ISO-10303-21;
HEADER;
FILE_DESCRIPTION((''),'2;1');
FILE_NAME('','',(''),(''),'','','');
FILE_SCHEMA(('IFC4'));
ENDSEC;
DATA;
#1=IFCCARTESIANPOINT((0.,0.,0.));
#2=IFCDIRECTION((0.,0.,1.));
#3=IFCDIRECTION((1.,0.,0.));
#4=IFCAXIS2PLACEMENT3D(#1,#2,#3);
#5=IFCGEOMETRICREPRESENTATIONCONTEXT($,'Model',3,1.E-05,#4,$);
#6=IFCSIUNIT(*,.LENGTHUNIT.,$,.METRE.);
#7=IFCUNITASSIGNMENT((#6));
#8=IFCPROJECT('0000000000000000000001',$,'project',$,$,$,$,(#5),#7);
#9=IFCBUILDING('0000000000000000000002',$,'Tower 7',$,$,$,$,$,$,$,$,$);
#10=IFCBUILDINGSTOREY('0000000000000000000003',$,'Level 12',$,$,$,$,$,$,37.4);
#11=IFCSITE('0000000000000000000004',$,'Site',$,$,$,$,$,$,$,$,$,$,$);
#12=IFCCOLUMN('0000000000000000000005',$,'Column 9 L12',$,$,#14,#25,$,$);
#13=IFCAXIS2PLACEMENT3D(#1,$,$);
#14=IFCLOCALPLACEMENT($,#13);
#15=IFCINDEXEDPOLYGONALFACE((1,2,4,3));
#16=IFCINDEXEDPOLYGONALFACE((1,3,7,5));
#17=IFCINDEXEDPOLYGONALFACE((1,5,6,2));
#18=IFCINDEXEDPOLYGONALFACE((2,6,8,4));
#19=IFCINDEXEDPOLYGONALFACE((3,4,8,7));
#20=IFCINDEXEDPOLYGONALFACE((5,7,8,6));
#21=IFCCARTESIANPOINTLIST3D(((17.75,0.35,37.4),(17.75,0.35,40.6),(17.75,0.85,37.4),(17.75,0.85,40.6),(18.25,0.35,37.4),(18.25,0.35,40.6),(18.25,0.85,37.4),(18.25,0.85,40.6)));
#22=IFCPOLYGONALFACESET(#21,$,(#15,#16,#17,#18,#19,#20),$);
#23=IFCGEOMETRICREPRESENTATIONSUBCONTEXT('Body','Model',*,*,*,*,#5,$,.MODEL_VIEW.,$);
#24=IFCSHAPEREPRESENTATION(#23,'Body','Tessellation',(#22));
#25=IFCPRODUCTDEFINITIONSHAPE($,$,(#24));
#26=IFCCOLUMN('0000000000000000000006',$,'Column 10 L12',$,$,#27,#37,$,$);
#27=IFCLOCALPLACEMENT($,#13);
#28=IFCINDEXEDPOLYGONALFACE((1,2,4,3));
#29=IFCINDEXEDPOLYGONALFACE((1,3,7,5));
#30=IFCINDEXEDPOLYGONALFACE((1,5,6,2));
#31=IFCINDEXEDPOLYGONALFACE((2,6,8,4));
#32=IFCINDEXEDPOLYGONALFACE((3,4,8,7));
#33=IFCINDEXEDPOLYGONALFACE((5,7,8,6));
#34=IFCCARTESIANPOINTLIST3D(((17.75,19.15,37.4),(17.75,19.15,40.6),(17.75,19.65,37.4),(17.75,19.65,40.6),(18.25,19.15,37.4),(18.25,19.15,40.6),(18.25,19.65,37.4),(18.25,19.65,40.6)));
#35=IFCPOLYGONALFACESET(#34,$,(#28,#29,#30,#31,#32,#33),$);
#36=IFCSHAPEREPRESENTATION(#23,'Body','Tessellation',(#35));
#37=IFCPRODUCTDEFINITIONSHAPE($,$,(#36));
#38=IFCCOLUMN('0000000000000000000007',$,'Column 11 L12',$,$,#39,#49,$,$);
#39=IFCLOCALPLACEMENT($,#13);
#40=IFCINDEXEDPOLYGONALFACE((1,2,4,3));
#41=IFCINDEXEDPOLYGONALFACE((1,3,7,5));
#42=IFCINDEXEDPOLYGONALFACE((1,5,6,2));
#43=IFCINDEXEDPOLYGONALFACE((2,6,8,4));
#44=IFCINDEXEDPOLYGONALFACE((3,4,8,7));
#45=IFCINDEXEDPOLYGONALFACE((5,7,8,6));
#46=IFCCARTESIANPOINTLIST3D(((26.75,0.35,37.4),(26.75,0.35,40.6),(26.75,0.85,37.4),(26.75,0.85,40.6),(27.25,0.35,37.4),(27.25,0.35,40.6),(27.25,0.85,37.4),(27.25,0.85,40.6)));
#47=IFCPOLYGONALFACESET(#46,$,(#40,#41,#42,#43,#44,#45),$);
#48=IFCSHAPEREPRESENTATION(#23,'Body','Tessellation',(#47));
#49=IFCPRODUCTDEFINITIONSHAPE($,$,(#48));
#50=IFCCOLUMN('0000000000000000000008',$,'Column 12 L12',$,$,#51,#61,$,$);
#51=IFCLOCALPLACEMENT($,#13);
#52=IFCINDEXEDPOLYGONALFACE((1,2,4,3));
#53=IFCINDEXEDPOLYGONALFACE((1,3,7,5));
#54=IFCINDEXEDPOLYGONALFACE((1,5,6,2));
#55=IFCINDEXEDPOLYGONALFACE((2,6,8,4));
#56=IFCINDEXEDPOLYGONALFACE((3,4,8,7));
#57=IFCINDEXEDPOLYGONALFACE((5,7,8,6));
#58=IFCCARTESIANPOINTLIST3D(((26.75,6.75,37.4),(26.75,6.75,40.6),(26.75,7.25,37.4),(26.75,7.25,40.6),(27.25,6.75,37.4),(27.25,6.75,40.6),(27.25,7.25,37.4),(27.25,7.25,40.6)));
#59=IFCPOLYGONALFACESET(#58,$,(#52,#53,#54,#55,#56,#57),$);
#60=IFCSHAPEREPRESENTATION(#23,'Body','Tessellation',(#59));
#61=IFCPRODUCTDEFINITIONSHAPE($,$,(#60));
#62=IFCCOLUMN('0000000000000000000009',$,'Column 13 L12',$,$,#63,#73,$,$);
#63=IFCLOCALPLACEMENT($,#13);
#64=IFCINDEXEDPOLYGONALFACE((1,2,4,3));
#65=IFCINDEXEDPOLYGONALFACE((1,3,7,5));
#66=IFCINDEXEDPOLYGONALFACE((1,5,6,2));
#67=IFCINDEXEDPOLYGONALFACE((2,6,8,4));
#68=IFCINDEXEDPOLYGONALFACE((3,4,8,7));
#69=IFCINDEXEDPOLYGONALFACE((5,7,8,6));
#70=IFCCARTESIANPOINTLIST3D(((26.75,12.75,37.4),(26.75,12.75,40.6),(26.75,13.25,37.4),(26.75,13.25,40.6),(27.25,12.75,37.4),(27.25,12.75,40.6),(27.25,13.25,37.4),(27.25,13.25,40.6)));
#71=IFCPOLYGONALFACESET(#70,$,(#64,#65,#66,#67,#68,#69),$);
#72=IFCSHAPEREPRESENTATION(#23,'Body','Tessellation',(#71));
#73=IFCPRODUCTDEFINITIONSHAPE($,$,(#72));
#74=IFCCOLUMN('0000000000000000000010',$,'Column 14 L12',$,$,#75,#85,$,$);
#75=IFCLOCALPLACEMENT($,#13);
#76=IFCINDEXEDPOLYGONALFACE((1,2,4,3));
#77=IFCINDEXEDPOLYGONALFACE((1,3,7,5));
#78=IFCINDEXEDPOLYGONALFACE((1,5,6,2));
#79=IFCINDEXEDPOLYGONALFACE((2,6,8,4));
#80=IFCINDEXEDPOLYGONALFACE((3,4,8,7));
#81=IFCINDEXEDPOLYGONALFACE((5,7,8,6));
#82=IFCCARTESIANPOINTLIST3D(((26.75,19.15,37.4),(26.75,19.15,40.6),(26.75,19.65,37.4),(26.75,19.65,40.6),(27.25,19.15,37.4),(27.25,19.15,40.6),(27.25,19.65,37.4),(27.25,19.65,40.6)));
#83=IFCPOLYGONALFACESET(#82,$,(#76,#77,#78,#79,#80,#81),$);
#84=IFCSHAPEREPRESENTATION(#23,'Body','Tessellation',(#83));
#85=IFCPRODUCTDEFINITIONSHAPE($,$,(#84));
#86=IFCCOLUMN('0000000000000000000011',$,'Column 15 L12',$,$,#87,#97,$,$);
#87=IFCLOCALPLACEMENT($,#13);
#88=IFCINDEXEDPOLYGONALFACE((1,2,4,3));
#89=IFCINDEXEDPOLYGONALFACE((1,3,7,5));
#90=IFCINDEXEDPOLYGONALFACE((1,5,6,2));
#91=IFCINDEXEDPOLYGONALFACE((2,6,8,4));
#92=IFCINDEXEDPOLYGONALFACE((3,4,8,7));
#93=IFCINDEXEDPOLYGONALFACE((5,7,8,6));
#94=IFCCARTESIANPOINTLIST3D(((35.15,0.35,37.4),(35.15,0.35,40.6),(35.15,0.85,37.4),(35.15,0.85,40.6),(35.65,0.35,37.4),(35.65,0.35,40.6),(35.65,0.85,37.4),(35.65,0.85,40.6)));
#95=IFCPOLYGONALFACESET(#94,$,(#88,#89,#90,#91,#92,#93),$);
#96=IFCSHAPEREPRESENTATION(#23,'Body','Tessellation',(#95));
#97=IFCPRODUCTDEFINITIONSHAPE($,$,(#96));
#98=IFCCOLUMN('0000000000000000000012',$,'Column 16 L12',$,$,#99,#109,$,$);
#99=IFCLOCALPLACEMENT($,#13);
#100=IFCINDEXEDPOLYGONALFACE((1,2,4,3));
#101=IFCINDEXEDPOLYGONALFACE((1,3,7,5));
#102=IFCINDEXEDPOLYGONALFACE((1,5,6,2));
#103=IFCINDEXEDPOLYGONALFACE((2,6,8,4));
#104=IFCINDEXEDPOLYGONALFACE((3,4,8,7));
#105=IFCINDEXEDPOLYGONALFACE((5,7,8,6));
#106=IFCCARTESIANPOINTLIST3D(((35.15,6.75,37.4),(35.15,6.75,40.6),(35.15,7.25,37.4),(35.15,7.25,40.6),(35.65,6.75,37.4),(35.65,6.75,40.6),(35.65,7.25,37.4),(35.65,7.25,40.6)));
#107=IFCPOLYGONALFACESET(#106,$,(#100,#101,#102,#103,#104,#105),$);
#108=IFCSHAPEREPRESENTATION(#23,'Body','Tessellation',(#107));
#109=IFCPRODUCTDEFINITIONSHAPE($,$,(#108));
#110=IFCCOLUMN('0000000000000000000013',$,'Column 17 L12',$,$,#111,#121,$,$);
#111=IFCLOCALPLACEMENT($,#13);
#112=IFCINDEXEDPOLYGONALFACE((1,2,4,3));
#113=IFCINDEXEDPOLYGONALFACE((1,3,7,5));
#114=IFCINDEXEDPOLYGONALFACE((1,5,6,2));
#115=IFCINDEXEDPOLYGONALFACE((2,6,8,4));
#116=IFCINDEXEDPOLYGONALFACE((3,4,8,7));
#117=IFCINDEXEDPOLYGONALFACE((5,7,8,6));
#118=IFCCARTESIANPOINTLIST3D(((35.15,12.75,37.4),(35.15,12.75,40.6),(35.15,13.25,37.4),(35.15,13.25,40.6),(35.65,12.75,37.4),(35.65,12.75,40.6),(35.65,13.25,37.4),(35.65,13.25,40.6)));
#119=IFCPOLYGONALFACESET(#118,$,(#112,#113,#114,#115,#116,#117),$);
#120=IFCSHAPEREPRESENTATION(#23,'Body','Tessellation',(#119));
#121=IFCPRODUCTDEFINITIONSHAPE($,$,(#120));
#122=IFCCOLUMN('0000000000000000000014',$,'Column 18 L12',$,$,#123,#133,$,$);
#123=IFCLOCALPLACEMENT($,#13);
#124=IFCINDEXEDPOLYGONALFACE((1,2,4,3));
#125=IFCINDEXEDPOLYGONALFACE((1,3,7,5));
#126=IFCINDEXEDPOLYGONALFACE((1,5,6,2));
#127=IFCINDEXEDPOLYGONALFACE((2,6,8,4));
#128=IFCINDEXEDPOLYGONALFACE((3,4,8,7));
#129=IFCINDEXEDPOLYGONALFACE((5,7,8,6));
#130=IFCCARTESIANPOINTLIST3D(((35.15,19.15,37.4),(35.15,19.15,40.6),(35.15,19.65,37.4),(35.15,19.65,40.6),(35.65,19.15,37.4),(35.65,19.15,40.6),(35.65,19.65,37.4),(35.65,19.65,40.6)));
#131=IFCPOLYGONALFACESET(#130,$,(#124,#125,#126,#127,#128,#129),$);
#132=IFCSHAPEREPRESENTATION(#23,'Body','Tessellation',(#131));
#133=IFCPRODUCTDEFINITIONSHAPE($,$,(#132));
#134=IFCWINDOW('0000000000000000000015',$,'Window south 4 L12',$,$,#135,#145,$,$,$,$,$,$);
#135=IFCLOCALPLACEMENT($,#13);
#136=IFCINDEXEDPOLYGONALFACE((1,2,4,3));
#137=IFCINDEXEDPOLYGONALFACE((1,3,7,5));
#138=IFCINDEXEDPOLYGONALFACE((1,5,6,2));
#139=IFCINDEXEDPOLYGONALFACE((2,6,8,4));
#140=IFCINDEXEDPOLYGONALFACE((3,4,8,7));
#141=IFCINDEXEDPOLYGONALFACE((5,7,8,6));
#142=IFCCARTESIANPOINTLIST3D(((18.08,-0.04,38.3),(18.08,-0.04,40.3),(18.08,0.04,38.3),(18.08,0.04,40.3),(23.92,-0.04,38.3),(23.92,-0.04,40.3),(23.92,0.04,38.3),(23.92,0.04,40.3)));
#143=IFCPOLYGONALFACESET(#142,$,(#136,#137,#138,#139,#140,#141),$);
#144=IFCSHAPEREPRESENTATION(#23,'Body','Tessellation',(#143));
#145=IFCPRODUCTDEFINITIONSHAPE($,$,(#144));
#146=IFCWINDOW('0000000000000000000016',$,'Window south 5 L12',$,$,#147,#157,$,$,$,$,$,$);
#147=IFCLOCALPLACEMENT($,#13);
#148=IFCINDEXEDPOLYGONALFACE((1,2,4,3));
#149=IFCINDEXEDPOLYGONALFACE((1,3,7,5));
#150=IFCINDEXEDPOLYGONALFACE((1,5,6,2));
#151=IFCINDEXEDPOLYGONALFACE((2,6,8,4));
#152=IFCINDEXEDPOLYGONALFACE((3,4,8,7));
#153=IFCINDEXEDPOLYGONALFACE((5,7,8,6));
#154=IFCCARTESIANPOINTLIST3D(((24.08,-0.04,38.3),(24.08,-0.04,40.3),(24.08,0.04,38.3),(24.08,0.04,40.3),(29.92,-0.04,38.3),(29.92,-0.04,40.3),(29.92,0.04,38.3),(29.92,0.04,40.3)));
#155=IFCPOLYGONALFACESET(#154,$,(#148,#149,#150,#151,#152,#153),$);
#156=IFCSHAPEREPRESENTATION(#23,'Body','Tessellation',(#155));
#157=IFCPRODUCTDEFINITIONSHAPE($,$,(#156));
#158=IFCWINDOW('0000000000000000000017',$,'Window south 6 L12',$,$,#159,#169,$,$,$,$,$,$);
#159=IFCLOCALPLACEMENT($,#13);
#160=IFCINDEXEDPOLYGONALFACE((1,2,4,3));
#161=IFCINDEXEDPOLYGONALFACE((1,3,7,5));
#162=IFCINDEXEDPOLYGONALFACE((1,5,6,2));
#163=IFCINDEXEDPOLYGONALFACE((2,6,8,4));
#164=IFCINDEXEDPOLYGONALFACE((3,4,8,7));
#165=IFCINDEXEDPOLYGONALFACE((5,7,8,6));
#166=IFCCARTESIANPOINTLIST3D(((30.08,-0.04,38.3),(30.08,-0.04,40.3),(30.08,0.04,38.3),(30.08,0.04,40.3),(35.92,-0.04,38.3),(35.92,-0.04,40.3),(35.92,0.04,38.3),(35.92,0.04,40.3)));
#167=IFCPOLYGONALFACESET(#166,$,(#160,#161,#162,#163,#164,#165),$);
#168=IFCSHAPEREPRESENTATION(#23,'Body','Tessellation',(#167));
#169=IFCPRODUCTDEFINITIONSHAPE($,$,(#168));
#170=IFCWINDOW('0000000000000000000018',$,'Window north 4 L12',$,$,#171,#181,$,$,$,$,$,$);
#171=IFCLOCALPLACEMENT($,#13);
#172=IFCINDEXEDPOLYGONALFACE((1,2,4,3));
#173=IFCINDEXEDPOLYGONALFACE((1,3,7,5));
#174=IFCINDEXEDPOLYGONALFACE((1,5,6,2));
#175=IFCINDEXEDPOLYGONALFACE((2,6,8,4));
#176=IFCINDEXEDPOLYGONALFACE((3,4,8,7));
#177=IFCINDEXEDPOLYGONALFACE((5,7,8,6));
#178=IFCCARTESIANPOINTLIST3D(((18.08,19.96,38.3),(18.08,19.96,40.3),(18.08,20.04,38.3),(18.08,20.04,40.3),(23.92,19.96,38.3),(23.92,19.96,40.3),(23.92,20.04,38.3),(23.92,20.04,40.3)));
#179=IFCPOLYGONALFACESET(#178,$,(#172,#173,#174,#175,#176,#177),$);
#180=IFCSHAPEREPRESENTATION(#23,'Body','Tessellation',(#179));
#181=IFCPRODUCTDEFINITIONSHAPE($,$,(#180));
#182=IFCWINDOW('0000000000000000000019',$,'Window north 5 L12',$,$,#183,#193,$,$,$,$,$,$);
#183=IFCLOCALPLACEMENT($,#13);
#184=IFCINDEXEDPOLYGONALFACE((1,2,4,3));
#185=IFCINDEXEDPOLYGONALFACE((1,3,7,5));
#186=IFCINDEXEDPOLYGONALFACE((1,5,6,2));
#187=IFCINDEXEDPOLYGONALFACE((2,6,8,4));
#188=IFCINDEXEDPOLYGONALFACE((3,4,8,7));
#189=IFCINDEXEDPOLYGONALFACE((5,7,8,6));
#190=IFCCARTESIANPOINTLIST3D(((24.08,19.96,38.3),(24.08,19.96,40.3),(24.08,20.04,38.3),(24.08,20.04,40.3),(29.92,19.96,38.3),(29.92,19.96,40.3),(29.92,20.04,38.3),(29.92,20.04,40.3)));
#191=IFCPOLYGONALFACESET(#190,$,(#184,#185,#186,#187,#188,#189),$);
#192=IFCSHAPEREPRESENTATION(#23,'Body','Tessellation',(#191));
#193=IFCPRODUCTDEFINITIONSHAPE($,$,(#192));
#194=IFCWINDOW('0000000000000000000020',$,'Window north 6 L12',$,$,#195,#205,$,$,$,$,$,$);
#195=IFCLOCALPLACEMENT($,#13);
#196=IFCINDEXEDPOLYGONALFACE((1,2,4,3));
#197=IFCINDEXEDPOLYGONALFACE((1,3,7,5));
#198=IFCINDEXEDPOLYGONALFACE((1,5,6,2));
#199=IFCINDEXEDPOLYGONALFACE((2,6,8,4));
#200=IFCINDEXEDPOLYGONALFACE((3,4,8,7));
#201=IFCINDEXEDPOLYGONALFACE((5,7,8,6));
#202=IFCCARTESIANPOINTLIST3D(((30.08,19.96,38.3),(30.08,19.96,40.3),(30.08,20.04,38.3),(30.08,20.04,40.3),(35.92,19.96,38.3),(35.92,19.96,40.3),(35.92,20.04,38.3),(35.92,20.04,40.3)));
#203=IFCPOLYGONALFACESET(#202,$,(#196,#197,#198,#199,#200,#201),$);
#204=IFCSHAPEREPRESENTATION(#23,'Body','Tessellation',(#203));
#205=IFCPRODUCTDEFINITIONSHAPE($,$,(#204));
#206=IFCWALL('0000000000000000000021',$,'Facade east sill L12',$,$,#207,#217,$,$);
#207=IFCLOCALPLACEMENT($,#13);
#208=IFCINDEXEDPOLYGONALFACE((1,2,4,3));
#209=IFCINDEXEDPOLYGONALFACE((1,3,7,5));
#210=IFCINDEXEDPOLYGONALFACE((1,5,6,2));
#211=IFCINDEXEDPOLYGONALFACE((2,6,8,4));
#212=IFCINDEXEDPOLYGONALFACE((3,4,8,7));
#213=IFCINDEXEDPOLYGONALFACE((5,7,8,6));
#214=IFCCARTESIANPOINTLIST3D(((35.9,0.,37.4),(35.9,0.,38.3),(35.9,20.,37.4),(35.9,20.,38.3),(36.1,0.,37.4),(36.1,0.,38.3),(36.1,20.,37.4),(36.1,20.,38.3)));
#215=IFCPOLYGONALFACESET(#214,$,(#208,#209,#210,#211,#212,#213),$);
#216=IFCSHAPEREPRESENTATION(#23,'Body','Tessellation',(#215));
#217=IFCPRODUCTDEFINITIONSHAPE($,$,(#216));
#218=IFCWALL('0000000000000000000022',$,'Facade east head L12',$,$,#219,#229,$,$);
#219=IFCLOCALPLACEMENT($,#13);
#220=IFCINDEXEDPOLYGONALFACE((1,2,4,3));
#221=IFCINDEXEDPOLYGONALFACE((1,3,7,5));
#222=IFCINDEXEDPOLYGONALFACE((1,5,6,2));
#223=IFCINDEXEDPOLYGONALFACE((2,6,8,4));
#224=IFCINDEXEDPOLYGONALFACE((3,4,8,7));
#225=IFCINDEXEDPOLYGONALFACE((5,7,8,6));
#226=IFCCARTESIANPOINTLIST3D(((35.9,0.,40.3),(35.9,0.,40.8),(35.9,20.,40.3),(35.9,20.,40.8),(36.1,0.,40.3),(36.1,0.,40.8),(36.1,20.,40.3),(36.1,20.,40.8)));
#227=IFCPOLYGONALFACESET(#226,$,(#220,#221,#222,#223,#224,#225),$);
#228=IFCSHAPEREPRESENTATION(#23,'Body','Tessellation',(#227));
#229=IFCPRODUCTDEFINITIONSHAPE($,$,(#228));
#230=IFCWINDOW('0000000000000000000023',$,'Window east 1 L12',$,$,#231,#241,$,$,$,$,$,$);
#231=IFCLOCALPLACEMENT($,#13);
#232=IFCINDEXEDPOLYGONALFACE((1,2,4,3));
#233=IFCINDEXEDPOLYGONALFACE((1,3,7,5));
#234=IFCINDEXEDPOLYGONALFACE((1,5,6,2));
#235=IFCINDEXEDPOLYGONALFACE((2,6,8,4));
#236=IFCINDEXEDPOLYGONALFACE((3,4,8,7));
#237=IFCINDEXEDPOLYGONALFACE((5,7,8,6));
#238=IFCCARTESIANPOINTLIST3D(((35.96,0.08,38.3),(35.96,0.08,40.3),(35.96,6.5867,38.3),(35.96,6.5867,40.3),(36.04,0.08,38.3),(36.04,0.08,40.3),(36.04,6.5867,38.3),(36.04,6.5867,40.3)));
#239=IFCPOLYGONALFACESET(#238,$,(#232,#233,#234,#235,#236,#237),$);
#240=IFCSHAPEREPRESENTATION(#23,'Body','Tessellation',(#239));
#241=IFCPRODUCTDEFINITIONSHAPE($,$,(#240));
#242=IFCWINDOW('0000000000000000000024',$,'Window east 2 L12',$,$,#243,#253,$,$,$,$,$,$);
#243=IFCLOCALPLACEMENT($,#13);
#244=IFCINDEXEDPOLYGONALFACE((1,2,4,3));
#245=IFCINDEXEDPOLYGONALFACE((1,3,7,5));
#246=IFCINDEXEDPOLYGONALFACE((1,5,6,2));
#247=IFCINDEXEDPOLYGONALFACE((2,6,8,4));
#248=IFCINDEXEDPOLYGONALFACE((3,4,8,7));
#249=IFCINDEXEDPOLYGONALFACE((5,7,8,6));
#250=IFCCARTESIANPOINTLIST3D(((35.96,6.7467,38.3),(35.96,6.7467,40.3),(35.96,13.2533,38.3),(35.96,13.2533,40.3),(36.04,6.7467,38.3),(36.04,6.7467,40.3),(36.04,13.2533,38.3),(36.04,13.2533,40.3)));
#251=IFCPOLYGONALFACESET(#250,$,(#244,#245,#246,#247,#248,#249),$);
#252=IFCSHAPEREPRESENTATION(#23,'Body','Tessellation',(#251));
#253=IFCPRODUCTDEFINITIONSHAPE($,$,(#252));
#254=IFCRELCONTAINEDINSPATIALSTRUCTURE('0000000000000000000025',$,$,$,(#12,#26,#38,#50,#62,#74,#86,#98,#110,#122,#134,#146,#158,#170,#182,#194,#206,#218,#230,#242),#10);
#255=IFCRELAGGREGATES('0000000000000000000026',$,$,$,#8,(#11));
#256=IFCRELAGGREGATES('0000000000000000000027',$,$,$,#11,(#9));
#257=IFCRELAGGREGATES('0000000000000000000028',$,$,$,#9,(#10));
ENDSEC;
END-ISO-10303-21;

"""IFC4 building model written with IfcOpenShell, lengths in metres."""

from ifc_helpers import new_model, si_unit, frame, origin, origin_with_axes, origin_2d, place, context, subcontext, project, spatial, rectangle, extrude, element, save


model = new_model("IFC4")

# Units and contexts
model_context = context("Model", 3, precision=1e-05, world=origin_with_axes())
body_context = subcontext(model_context, "Body", "Model", "MODEL_VIEW")
ifc_project = project(units=[si_unit("LENGTHUNIT", "METRE")], contexts=[model_context])

# Site, building, storey
site = spatial("IfcSite", under=ifc_project, Name="Site")
building = spatial("IfcBuilding", under=site, Name="Tower 7")
storey = spatial("IfcBuildingStorey", under=building, Name="Level 12", Elevation=37.4)

# Columns
for number, where, z_axis, x_axis, name in (
    (1, (18.0, 0.6, 37.4), (0.0, 0.0, 1.0), (1.0, 0.0, 0.0), "Column 9 L12"),
    (2, (18.0, 19.4, 37.4), (0.0, 0.0, 1.0), (1.0, 0.0, 0.0), "Column 10 L12"),
    (3, (27.0, 0.6, 37.4), (0.0, 0.0, 1.0), (1.0, 0.0, 0.0), "Column 11 L12"),
    (4, (27.0, 7.0, 37.4), (0.0, 0.0, 1.0), (1.0, 0.0, 0.0), "Column 12 L12"),
    (5, (27.0, 13.0, 37.4), (0.0, 0.0, 1.0), (1.0, 0.0, 0.0), "Column 13 L12"),
    (6, (27.0, 19.4, 37.4), (0.0, 0.0, 1.0), (1.0, 0.0, 0.0), "Column 14 L12"),
    (7, (35.4, 0.6, 37.4), (0.0, 0.0, 1.0), (1.0, 0.0, 0.0), "Column 15 L12"),
    (8, (35.4, 7.0, 37.4), (0.0, 0.0, 1.0), (1.0, 0.0, 0.0), "Column 16 L12"),
    (9, (35.4, 13.0, 37.4), (0.0, 0.0, 1.0), (1.0, 0.0, 0.0), "Column 17 L12"),
    (10, (35.4, 19.4, 37.4), (0.0, 0.0, 1.0), (1.0, 0.0, 0.0), "Column 18 L12"),
):
    element("IfcColumn", number, at=place(None, frame(where, z_axis=z_axis, x_axis=x_axis)), inside=storey, Name=name, context=body_context, shape_type="SweptSolid", body=[
        extrude(rectangle(XDim=0.5, YDim=0.5, at=origin_2d()), origin(), (0.0, 0.0, 1.0), 3.2),
    ])

# Windows
for number, where, z_axis, x_axis, name in (
    (11, (21.0, 0.0, 38.3), (0.0, 0.0, 1.0), (1.0, 0.0, 0.0), "Window south 4 L12"),
    (12, (27.0, 0.0, 38.3), (0.0, 0.0, 1.0), (1.0, 0.0, 0.0), "Window south 5 L12"),
    (13, (33.0, 0.0, 38.3), (0.0, 0.0, 1.0), (1.0, 0.0, 0.0), "Window south 6 L12"),
):
    element("IfcWindow", number, at=place(None, frame(where, z_axis=z_axis, x_axis=x_axis)), inside=storey, Name=name, context=body_context, shape_type="SweptSolid", body=[
        extrude(rectangle(XDim=5.84, YDim=0.08, at=origin_2d()), origin(), (0.0, 0.0, 1.0), 2.0),
    ])
for number, where, z_axis, x_axis, name in (
    (14, (21.0, 20.0, 38.3), (0.0, 0.0, 1.0), (1.0, 0.0, 0.0), "Window north 4 L12"),
    (15, (27.0, 20.0, 38.3), (0.0, 0.0, 1.0), (1.0, 0.0, 0.0), "Window north 5 L12"),
    (16, (33.0, 20.0, 38.3), (0.0, 0.0, 1.0), (1.0, 0.0, 0.0), "Window north 6 L12"),
):
    element("IfcWindow", number, at=place(None, frame(where, z_axis=z_axis, x_axis=x_axis)), inside=storey, Name=name, context=body_context, shape_type="SweptSolid", body=[
        extrude(rectangle(XDim=5.84, YDim=0.08, at=origin_2d()), origin(), (0.0, 0.0, 1.0), 2.0),
    ])

# Walls
wall_1_placement = place(None, frame((36.0, 10.0, 37.4), z_axis=(0.0, 0.0, 1.0), x_axis=(1.0, 0.0, 0.0)))
element("IfcWall", 17, at=wall_1_placement, inside=storey, Name="Facade east sill L12", context=body_context, shape_type="SweptSolid", body=[
    extrude(rectangle(XDim=0.2, YDim=20.0, at=origin_2d()), origin(), (0.0, 0.0, 1.0), 0.9),
])
wall_2_placement = place(None, frame((36.0, 10.0, 40.3), z_axis=(0.0, 0.0, 1.0), x_axis=(1.0, 0.0, 0.0)))
element("IfcWall", 18, at=wall_2_placement, inside=storey, Name="Facade east head L12", context=body_context, shape_type="SweptSolid", body=[
    extrude(rectangle(XDim=0.2, YDim=20.0, at=origin_2d()), origin(), (0.0, 0.0, 1.0), 0.5),
])

# Windows
for number, where, z_axis, x_axis, name in (
    (19, (36.0, 3.3333, 38.3), (0.0, 0.0, 1.0), (1.0, 0.0, 0.0), "Window east 1 L12"),
    (20, (36.0, 10.0, 38.3), (0.0, 0.0, 1.0), (1.0, 0.0, 0.0), "Window east 2 L12"),
):
    element("IfcWindow", number, at=place(None, frame(where, z_axis=z_axis, x_axis=x_axis)), inside=storey, Name=name, context=body_context, shape_type="SweptSolid", body=[
        extrude(rectangle(XDim=0.08, YDim=6.5067, at=origin_2d()), origin(), (0.0, 0.0, 1.0), 2.0),
    ])

save(model, "model.ifc")
